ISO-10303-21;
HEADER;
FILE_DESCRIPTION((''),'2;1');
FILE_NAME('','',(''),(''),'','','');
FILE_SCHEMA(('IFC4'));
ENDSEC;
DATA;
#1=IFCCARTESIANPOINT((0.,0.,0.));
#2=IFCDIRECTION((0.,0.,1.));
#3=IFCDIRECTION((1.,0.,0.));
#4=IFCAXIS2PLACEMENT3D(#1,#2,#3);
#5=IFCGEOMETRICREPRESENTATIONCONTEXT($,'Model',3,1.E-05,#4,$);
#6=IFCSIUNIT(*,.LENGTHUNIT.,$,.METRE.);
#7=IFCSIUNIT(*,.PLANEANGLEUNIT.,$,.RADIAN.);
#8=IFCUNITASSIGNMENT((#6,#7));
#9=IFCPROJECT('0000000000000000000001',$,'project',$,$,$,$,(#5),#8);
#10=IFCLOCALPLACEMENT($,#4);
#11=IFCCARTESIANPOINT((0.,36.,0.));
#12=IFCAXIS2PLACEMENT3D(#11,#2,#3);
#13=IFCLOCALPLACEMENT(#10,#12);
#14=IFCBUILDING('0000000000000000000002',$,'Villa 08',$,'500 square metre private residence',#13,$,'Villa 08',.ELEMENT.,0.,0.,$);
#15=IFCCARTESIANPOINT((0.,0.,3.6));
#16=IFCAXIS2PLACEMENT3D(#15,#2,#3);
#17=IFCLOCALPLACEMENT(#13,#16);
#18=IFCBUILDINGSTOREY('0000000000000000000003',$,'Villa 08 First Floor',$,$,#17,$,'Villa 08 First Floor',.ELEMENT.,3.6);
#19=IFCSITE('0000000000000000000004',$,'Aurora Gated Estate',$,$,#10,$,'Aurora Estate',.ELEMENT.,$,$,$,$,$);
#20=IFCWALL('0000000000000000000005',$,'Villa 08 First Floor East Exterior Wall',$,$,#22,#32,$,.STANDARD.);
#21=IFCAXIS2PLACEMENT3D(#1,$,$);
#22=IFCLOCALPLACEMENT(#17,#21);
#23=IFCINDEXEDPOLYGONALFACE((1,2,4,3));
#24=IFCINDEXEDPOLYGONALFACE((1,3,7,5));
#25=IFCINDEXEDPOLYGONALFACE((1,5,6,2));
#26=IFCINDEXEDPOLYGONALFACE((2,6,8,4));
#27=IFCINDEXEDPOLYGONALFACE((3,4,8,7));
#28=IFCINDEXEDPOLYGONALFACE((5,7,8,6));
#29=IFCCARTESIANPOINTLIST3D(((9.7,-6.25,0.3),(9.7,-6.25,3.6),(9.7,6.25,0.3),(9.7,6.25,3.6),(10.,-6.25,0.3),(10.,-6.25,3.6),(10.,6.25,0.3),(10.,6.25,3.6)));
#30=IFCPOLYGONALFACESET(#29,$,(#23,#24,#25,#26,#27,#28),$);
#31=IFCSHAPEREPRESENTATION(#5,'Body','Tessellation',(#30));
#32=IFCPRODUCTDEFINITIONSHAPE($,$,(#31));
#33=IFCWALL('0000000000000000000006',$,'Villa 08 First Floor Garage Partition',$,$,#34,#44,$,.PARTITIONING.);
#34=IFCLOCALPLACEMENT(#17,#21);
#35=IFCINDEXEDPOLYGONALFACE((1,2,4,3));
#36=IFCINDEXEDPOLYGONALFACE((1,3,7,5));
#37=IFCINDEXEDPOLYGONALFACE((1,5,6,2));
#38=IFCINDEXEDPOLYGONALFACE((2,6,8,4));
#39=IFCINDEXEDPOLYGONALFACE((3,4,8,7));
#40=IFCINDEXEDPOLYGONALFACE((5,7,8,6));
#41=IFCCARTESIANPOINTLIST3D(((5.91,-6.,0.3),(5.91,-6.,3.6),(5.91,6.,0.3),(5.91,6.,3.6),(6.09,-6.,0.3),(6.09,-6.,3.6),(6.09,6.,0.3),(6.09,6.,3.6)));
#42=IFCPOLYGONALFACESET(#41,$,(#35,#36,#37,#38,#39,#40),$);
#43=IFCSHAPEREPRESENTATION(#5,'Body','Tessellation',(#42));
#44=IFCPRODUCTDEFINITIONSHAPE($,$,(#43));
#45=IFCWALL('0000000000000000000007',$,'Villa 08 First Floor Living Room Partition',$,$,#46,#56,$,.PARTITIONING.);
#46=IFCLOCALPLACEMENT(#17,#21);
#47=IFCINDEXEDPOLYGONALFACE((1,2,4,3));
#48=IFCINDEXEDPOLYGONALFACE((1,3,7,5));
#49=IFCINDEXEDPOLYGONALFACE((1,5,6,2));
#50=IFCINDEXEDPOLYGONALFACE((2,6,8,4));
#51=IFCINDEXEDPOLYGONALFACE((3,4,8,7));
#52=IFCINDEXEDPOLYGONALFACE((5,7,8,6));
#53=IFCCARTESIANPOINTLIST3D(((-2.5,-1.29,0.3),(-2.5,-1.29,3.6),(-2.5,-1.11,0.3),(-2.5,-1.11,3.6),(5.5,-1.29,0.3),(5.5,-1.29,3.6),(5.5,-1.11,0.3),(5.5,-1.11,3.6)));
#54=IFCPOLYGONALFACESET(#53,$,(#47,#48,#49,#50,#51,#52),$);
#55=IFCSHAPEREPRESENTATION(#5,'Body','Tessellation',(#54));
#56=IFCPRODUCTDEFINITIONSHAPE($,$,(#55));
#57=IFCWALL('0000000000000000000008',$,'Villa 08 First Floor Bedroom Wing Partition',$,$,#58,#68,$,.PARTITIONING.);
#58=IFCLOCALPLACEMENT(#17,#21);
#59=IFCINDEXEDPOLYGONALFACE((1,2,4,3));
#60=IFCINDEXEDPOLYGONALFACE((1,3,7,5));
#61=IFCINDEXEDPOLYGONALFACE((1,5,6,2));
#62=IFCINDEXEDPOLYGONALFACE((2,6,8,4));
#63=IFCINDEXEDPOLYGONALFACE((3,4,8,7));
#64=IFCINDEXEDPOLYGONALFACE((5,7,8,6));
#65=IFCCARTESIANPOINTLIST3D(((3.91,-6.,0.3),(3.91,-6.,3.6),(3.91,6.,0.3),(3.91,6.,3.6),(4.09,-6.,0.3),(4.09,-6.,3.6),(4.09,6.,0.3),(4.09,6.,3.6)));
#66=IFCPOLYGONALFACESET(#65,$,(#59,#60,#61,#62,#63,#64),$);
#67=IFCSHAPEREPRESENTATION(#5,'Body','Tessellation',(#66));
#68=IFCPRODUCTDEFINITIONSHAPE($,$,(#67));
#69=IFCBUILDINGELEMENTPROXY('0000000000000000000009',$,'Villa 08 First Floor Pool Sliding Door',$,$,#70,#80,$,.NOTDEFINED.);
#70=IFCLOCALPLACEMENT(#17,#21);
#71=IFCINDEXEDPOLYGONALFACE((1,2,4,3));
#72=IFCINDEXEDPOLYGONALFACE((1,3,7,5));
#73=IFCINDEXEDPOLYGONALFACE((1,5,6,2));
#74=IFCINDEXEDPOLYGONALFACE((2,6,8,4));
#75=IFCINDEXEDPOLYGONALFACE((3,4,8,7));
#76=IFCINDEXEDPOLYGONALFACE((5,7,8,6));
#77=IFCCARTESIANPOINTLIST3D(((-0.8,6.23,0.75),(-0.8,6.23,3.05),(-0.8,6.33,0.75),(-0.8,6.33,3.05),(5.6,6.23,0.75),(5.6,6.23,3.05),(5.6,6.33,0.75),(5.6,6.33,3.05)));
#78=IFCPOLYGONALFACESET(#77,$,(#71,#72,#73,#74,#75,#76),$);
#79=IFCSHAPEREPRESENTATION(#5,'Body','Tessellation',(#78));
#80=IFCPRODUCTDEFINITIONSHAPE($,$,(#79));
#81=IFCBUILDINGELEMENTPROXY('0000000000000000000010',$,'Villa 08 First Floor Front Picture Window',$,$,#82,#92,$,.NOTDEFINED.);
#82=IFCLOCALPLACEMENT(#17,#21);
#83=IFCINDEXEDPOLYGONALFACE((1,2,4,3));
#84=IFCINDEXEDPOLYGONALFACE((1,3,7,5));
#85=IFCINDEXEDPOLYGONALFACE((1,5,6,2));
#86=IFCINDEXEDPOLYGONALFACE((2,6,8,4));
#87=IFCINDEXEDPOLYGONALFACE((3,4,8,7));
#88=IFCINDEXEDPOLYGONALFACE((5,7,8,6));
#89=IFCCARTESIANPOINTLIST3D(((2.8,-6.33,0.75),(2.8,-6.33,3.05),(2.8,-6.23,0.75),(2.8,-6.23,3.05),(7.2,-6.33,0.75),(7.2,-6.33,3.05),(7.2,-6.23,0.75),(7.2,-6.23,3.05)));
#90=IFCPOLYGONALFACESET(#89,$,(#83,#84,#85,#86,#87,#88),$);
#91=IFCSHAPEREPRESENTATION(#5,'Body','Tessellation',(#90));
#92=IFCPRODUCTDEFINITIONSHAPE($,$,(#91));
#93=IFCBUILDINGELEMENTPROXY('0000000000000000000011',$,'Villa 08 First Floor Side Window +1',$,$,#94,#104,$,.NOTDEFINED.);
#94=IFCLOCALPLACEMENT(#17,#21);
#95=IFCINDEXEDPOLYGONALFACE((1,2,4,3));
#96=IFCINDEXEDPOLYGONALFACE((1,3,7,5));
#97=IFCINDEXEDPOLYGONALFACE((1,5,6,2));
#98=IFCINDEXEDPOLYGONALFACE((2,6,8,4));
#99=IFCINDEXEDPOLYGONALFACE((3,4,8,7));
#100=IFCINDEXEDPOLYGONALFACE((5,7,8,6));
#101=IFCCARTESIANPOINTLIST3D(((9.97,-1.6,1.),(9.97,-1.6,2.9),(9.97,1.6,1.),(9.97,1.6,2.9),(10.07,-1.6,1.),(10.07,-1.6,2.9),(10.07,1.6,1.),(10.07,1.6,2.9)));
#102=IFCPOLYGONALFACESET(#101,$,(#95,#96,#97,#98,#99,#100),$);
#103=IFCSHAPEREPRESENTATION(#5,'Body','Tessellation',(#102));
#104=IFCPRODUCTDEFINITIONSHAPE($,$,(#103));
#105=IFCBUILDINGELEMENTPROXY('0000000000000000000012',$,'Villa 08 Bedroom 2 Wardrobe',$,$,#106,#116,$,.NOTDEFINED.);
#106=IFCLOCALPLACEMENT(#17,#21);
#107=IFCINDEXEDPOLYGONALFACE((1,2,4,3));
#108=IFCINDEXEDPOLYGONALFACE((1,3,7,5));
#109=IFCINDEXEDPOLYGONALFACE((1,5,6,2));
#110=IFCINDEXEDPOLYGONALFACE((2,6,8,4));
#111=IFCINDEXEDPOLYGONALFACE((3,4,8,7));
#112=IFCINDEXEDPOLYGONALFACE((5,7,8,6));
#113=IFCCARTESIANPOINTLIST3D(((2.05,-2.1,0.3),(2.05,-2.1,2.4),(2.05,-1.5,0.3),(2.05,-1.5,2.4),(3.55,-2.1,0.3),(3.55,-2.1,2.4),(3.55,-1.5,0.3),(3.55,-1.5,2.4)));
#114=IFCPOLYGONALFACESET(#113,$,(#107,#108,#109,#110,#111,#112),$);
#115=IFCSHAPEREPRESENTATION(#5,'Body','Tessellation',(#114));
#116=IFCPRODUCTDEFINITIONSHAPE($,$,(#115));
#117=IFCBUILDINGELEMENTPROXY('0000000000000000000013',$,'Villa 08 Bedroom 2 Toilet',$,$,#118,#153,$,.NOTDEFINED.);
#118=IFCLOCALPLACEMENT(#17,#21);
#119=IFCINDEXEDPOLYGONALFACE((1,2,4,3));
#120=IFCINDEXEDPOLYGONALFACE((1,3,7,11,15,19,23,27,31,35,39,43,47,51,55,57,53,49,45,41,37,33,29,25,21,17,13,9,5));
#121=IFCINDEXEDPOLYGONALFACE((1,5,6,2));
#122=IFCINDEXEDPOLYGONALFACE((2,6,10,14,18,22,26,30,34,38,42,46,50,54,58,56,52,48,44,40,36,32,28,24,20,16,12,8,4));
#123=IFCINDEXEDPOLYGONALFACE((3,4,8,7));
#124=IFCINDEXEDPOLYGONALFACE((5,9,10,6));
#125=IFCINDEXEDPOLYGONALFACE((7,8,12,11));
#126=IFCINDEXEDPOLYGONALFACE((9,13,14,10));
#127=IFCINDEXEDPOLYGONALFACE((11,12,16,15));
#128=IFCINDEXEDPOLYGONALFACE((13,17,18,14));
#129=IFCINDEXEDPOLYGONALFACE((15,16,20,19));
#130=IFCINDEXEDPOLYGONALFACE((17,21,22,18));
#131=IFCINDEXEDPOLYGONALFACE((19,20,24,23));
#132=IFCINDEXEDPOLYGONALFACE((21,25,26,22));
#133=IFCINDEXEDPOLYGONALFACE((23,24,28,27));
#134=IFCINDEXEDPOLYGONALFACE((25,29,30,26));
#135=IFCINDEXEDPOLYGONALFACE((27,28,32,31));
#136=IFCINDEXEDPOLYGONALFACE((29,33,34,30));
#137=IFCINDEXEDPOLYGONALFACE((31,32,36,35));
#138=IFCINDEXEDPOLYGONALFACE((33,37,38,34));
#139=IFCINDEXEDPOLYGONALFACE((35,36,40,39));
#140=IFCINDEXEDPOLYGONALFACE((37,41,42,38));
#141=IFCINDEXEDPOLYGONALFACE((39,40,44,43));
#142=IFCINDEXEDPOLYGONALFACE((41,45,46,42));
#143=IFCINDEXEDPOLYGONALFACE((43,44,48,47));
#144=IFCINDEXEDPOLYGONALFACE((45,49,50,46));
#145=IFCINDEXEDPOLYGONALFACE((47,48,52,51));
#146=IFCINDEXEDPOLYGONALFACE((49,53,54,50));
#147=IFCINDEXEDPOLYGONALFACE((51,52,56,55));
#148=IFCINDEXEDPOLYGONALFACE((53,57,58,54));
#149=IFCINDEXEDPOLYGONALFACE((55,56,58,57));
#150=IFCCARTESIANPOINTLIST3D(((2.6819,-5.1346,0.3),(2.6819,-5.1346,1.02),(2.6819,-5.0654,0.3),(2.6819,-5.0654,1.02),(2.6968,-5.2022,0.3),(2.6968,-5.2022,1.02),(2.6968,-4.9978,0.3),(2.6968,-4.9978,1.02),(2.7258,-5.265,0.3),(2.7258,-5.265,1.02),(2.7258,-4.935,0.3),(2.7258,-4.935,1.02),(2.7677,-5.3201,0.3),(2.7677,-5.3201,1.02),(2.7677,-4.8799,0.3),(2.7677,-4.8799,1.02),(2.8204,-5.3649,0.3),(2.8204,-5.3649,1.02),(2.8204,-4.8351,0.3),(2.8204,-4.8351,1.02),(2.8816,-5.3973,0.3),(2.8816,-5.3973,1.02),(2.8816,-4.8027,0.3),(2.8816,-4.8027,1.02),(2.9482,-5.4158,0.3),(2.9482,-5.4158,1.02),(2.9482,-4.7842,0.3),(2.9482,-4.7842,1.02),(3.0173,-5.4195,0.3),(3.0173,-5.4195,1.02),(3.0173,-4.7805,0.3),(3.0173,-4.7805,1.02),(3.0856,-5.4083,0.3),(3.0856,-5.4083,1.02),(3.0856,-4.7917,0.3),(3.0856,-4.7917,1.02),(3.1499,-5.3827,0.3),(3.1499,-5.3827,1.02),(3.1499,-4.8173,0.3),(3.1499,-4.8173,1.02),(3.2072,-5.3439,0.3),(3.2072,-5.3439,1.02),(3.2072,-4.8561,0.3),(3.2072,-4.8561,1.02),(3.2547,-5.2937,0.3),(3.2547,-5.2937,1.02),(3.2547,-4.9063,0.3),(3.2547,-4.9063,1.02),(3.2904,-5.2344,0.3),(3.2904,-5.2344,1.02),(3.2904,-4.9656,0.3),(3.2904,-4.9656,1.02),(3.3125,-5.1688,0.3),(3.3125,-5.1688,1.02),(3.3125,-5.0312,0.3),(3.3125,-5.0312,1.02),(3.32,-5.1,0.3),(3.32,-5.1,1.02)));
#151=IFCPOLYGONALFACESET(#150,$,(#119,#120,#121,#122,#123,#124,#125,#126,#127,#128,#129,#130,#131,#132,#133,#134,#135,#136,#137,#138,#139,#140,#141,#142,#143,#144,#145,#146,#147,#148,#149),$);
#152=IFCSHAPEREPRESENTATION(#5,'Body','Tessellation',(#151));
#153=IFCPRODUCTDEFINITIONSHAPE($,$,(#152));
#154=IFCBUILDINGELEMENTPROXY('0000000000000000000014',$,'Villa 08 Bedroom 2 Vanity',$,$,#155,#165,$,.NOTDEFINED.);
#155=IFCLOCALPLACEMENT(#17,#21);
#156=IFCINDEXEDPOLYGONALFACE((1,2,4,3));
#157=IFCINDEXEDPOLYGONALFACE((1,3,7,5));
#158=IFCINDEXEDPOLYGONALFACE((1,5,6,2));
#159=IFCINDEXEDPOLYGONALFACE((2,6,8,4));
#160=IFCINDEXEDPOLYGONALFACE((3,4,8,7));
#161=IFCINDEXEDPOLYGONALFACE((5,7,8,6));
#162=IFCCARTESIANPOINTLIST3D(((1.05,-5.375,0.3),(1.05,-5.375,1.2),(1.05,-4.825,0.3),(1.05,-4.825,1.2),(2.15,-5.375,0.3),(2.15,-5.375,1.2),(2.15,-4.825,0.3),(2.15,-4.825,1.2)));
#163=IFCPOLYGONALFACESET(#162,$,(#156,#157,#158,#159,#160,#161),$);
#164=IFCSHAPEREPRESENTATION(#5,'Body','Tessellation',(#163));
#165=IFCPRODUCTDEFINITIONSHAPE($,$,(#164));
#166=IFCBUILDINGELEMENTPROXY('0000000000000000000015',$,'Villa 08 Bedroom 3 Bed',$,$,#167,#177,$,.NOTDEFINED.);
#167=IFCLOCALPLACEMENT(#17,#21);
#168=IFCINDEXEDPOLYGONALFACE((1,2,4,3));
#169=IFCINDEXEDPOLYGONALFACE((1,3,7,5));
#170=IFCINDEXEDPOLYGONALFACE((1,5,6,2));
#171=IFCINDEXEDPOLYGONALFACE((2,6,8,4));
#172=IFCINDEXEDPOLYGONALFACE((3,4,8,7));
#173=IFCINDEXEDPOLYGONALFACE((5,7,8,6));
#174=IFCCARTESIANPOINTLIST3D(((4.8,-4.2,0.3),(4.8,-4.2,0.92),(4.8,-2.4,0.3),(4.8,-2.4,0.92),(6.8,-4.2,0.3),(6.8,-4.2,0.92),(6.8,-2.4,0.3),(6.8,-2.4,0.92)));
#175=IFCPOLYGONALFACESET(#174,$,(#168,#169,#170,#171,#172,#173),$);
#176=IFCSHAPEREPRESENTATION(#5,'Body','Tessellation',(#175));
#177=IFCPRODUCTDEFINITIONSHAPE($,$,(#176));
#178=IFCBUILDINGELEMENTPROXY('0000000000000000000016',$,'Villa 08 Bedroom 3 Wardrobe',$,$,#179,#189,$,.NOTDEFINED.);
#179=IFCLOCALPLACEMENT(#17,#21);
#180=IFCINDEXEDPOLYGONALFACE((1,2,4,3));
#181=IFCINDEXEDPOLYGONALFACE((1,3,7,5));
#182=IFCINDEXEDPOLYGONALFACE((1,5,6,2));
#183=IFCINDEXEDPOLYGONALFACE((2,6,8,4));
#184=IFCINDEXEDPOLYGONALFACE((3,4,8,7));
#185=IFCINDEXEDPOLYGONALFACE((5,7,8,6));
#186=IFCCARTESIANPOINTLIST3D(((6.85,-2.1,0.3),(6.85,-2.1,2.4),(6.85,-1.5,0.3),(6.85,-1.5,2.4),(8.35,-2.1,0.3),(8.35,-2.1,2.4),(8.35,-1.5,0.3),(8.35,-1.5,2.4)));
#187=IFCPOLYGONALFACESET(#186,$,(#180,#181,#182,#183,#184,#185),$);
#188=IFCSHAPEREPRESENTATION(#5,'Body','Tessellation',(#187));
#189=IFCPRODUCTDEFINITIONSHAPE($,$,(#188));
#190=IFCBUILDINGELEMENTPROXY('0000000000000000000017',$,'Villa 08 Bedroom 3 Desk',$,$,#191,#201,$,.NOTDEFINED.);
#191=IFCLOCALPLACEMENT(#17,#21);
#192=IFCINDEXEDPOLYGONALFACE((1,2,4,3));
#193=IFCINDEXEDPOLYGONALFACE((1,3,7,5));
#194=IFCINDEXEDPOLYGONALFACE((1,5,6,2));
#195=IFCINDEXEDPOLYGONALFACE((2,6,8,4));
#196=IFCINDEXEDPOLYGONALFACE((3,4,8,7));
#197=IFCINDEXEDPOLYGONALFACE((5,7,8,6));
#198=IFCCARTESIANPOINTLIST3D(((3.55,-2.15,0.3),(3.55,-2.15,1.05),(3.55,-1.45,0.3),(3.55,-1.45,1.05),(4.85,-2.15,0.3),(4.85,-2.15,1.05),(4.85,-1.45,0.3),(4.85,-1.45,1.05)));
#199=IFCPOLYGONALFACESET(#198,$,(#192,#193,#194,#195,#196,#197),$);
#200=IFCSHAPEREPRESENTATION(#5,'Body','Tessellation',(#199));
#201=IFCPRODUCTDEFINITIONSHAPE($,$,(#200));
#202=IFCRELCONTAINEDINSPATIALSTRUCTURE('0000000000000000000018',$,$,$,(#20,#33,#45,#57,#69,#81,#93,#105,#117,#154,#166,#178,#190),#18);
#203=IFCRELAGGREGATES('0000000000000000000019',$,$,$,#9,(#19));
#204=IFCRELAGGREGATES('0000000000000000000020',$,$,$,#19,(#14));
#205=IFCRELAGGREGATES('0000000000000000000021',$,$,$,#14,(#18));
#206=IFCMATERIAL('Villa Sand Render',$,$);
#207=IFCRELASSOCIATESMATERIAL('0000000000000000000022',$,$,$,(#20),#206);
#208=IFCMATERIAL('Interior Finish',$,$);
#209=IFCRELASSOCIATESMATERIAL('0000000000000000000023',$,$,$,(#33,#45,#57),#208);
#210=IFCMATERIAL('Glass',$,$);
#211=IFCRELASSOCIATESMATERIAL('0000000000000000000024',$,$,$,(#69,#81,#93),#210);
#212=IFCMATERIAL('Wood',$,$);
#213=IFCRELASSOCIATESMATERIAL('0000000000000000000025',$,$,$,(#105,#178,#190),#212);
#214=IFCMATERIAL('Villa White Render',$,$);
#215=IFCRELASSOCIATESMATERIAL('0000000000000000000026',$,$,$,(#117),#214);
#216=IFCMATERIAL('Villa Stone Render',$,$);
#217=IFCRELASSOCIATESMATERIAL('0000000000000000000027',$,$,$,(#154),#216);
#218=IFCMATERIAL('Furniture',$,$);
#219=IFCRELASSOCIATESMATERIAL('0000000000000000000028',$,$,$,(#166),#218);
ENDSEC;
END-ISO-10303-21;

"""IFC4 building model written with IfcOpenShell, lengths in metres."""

from ifc_helpers import new_model, si_unit, frame, origin_with_axes, origin_2d_with_axis, place, context, project, spatial, rectangle, circle, extrude, material, element, save


model = new_model("IFC4")

# Units and contexts
model_context = context("Model", 3, precision=1e-05, world=origin_with_axes())
ifc_project = project(units=[si_unit("LENGTHUNIT", "METRE"), si_unit("PLANEANGLEUNIT", "RADIAN")], contexts=[model_context])

# Site, building, storey
site_placement = place(None, origin_with_axes())
site = spatial("IfcSite", under=ifc_project, at=site_placement, Name="Aurora Gated Estate", LongName="Aurora Estate", CompositionType="ELEMENT")
building_placement = place(site_placement, frame((0.0, 36.0, 0.0), z_axis=(0.0, 0.0, 1.0), x_axis=(1.0, 0.0, 0.0)))
building = spatial("IfcBuilding", under=site, at=building_placement, Name="Villa 08", ObjectType="500 square metre private residence", LongName="Villa 08", CompositionType="ELEMENT", ElevationOfRefHeight=0.0, ElevationOfTerrain=0.0)
storey_placement = place(building_placement, frame((0.0, 0.0, 3.6), z_axis=(0.0, 0.0, 1.0), x_axis=(1.0, 0.0, 0.0)))
storey = spatial("IfcBuildingStorey", under=building, at=storey_placement, Name="Villa 08 First Floor", LongName="Villa 08 First Floor", CompositionType="ELEMENT", Elevation=3.6)

# Walls
ifc_material_1 = material(Name="Villa Sand Render")
wall_1_placement = place(storey_placement, frame((9.85, 0.0, 0.3), z_axis=(0.0, 0.0, 1.0), x_axis=(1.0, 0.0, 0.0)))
element("IfcWall", 1, at=wall_1_placement, inside=storey, material=ifc_material_1, Name="Villa 08 First Floor East Exterior Wall", PredefinedType="STANDARD", context=model_context, shape_type="SweptSolid", body=[
    extrude(rectangle(XDim=0.3, YDim=12.5, at=origin_2d_with_axis()), origin_with_axes(), (0.0, 0.0, 1.0), 3.3),
])
ifc_material_2 = material(Name="Interior Finish")
wall_2_placement = place(storey_placement, frame((6.0, 0.0, 0.3), z_axis=(0.0, 0.0, 1.0), x_axis=(1.0, 0.0, 0.0)))
element("IfcWall", 2, at=wall_2_placement, inside=storey, material=ifc_material_2, Name="Villa 08 First Floor Garage Partition", PredefinedType="PARTITIONING", context=model_context, shape_type="SweptSolid", body=[
    extrude(rectangle(XDim=0.18, YDim=12.0, at=origin_2d_with_axis()), origin_with_axes(), (0.0, 0.0, 1.0), 3.3),
])
wall_3_placement = place(storey_placement, frame((1.5, -1.2, 0.3), z_axis=(0.0, 0.0, 1.0), x_axis=(1.0, 0.0, 0.0)))
element("IfcWall", 3, at=wall_3_placement, inside=storey, material=ifc_material_2, Name="Villa 08 First Floor Living Room Partition", PredefinedType="PARTITIONING", context=model_context, shape_type="SweptSolid", body=[
    extrude(rectangle(XDim=8.0, YDim=0.18, at=origin_2d_with_axis()), origin_with_axes(), (0.0, 0.0, 1.0), 3.3),
])
wall_4_placement = place(storey_placement, frame((4.0, 0.0, 0.3), z_axis=(0.0, 0.0, 1.0), x_axis=(1.0, 0.0, 0.0)))
element("IfcWall", 4, at=wall_4_placement, inside=storey, material=ifc_material_2, Name="Villa 08 First Floor Bedroom Wing Partition", PredefinedType="PARTITIONING", context=model_context, shape_type="SweptSolid", body=[
    extrude(rectangle(XDim=0.18, YDim=12.0, at=origin_2d_with_axis()), origin_with_axes(), (0.0, 0.0, 1.0), 3.3),
])

# Building element proxies
ifc_material_3 = material(Name="Glass")
proxy_1_placement = place(storey_placement, frame((2.4, 6.28, 0.75), z_axis=(0.0, 0.0, 1.0), x_axis=(1.0, 0.0, 0.0)))
element("IfcBuildingElementProxy", 5, at=proxy_1_placement, inside=storey, material=ifc_material_3, Name="Villa 08 First Floor Pool Sliding Door", PredefinedType="NOTDEFINED", context=model_context, shape_type="SweptSolid", body=[
    extrude(rectangle(XDim=6.4, YDim=0.1, at=origin_2d_with_axis()), origin_with_axes(), (0.0, 0.0, 1.0), 2.3),
])
proxy_2_placement = place(storey_placement, frame((5.0, -6.28, 0.75), z_axis=(0.0, 0.0, 1.0), x_axis=(1.0, 0.0, 0.0)))
element("IfcBuildingElementProxy", 6, at=proxy_2_placement, inside=storey, material=ifc_material_3, Name="Villa 08 First Floor Front Picture Window", PredefinedType="NOTDEFINED", context=model_context, shape_type="SweptSolid", body=[
    extrude(rectangle(XDim=4.4, YDim=0.1, at=origin_2d_with_axis()), origin_with_axes(), (0.0, 0.0, 1.0), 2.3),
])
proxy_3_placement = place(storey_placement, frame((10.02, 0.0, 1.0), z_axis=(0.0, 0.0, 1.0), x_axis=(0.0, 1.0, 0.0)))
element("IfcBuildingElementProxy", 7, at=proxy_3_placement, inside=storey, material=ifc_material_3, Name="Villa 08 First Floor Side Window +1", PredefinedType="NOTDEFINED", context=model_context, shape_type="SweptSolid", body=[
    extrude(rectangle(XDim=3.2, YDim=0.1, at=origin_2d_with_axis()), origin_with_axes(), (0.0, 0.0, 1.0), 1.9),
])
ifc_material_4 = material(Name="Wood")
proxy_4_placement = place(storey_placement, frame((2.8, -1.8, 0.3), z_axis=(0.0, 0.0, 1.0), x_axis=(1.0, 0.0, 0.0)))
element("IfcBuildingElementProxy", 8, at=proxy_4_placement, inside=storey, material=ifc_material_4, Name="Villa 08 Bedroom 2 Wardrobe", PredefinedType="NOTDEFINED", context=model_context, shape_type="SweptSolid", body=[
    extrude(rectangle(XDim=1.5, YDim=0.6, at=origin_2d_with_axis()), origin_with_axes(), (0.0, 0.0, 1.0), 2.1),
])
ifc_material_5 = material(Name="Villa White Render")
proxy_5_placement = place(storey_placement, frame((3.0, -5.1, 0.3), z_axis=(0.0, 0.0, 1.0), x_axis=(1.0, 0.0, 0.0)))
element("IfcBuildingElementProxy", 9, at=proxy_5_placement, inside=storey, material=ifc_material_5, Name="Villa 08 Bedroom 2 Toilet", PredefinedType="NOTDEFINED", context=model_context, shape_type="SweptSolid", body=[
    extrude(circle(Radius=0.32, at=origin_2d_with_axis()), origin_with_axes(), (0.0, 0.0, 1.0), 0.72),
])
ifc_material_6 = material(Name="Villa Stone Render")
proxy_6_placement = place(storey_placement, frame((1.6, -5.1, 0.3), z_axis=(0.0, 0.0, 1.0), x_axis=(1.0, 0.0, 0.0)))
element("IfcBuildingElementProxy", 10, at=proxy_6_placement, inside=storey, material=ifc_material_6, Name="Villa 08 Bedroom 2 Vanity", PredefinedType="NOTDEFINED", context=model_context, shape_type="SweptSolid", body=[
    extrude(rectangle(XDim=1.1, YDim=0.55, at=origin_2d_with_axis()), origin_with_axes(), (0.0, 0.0, 1.0), 0.9),
])
ifc_material_7 = material(Name="Furniture")
proxy_7_placement = place(storey_placement, frame((5.8, -3.3, 0.3), z_axis=(0.0, 0.0, 1.0), x_axis=(1.0, 0.0, 0.0)))
element("IfcBuildingElementProxy", 11, at=proxy_7_placement, inside=storey, material=ifc_material_7, Name="Villa 08 Bedroom 3 Bed", PredefinedType="NOTDEFINED", context=model_context, shape_type="SweptSolid", body=[
    extrude(rectangle(XDim=2.0, YDim=1.8, at=origin_2d_with_axis()), origin_with_axes(), (0.0, 0.0, 1.0), 0.62),
])
proxy_8_placement = place(storey_placement, frame((7.6, -1.8, 0.3), z_axis=(0.0, 0.0, 1.0), x_axis=(1.0, 0.0, 0.0)))
element("IfcBuildingElementProxy", 12, at=proxy_8_placement, inside=storey, material=ifc_material_4, Name="Villa 08 Bedroom 3 Wardrobe", PredefinedType="NOTDEFINED", context=model_context, shape_type="SweptSolid", body=[
    extrude(rectangle(XDim=1.5, YDim=0.6, at=origin_2d_with_axis()), origin_with_axes(), (0.0, 0.0, 1.0), 2.1),
])
proxy_9_placement = place(storey_placement, frame((4.2, -1.8, 0.3), z_axis=(0.0, 0.0, 1.0), x_axis=(1.0, 0.0, 0.0)))
element("IfcBuildingElementProxy", 13, at=proxy_9_placement, inside=storey, material=ifc_material_4, Name="Villa 08 Bedroom 3 Desk", PredefinedType="NOTDEFINED", context=model_context, shape_type="SweptSolid", body=[
    extrude(rectangle(XDim=1.3, YDim=0.7, at=origin_2d_with_axis()), origin_with_axes(), (0.0, 0.0, 1.0), 0.75),
])

save(model, "model.ifc")
